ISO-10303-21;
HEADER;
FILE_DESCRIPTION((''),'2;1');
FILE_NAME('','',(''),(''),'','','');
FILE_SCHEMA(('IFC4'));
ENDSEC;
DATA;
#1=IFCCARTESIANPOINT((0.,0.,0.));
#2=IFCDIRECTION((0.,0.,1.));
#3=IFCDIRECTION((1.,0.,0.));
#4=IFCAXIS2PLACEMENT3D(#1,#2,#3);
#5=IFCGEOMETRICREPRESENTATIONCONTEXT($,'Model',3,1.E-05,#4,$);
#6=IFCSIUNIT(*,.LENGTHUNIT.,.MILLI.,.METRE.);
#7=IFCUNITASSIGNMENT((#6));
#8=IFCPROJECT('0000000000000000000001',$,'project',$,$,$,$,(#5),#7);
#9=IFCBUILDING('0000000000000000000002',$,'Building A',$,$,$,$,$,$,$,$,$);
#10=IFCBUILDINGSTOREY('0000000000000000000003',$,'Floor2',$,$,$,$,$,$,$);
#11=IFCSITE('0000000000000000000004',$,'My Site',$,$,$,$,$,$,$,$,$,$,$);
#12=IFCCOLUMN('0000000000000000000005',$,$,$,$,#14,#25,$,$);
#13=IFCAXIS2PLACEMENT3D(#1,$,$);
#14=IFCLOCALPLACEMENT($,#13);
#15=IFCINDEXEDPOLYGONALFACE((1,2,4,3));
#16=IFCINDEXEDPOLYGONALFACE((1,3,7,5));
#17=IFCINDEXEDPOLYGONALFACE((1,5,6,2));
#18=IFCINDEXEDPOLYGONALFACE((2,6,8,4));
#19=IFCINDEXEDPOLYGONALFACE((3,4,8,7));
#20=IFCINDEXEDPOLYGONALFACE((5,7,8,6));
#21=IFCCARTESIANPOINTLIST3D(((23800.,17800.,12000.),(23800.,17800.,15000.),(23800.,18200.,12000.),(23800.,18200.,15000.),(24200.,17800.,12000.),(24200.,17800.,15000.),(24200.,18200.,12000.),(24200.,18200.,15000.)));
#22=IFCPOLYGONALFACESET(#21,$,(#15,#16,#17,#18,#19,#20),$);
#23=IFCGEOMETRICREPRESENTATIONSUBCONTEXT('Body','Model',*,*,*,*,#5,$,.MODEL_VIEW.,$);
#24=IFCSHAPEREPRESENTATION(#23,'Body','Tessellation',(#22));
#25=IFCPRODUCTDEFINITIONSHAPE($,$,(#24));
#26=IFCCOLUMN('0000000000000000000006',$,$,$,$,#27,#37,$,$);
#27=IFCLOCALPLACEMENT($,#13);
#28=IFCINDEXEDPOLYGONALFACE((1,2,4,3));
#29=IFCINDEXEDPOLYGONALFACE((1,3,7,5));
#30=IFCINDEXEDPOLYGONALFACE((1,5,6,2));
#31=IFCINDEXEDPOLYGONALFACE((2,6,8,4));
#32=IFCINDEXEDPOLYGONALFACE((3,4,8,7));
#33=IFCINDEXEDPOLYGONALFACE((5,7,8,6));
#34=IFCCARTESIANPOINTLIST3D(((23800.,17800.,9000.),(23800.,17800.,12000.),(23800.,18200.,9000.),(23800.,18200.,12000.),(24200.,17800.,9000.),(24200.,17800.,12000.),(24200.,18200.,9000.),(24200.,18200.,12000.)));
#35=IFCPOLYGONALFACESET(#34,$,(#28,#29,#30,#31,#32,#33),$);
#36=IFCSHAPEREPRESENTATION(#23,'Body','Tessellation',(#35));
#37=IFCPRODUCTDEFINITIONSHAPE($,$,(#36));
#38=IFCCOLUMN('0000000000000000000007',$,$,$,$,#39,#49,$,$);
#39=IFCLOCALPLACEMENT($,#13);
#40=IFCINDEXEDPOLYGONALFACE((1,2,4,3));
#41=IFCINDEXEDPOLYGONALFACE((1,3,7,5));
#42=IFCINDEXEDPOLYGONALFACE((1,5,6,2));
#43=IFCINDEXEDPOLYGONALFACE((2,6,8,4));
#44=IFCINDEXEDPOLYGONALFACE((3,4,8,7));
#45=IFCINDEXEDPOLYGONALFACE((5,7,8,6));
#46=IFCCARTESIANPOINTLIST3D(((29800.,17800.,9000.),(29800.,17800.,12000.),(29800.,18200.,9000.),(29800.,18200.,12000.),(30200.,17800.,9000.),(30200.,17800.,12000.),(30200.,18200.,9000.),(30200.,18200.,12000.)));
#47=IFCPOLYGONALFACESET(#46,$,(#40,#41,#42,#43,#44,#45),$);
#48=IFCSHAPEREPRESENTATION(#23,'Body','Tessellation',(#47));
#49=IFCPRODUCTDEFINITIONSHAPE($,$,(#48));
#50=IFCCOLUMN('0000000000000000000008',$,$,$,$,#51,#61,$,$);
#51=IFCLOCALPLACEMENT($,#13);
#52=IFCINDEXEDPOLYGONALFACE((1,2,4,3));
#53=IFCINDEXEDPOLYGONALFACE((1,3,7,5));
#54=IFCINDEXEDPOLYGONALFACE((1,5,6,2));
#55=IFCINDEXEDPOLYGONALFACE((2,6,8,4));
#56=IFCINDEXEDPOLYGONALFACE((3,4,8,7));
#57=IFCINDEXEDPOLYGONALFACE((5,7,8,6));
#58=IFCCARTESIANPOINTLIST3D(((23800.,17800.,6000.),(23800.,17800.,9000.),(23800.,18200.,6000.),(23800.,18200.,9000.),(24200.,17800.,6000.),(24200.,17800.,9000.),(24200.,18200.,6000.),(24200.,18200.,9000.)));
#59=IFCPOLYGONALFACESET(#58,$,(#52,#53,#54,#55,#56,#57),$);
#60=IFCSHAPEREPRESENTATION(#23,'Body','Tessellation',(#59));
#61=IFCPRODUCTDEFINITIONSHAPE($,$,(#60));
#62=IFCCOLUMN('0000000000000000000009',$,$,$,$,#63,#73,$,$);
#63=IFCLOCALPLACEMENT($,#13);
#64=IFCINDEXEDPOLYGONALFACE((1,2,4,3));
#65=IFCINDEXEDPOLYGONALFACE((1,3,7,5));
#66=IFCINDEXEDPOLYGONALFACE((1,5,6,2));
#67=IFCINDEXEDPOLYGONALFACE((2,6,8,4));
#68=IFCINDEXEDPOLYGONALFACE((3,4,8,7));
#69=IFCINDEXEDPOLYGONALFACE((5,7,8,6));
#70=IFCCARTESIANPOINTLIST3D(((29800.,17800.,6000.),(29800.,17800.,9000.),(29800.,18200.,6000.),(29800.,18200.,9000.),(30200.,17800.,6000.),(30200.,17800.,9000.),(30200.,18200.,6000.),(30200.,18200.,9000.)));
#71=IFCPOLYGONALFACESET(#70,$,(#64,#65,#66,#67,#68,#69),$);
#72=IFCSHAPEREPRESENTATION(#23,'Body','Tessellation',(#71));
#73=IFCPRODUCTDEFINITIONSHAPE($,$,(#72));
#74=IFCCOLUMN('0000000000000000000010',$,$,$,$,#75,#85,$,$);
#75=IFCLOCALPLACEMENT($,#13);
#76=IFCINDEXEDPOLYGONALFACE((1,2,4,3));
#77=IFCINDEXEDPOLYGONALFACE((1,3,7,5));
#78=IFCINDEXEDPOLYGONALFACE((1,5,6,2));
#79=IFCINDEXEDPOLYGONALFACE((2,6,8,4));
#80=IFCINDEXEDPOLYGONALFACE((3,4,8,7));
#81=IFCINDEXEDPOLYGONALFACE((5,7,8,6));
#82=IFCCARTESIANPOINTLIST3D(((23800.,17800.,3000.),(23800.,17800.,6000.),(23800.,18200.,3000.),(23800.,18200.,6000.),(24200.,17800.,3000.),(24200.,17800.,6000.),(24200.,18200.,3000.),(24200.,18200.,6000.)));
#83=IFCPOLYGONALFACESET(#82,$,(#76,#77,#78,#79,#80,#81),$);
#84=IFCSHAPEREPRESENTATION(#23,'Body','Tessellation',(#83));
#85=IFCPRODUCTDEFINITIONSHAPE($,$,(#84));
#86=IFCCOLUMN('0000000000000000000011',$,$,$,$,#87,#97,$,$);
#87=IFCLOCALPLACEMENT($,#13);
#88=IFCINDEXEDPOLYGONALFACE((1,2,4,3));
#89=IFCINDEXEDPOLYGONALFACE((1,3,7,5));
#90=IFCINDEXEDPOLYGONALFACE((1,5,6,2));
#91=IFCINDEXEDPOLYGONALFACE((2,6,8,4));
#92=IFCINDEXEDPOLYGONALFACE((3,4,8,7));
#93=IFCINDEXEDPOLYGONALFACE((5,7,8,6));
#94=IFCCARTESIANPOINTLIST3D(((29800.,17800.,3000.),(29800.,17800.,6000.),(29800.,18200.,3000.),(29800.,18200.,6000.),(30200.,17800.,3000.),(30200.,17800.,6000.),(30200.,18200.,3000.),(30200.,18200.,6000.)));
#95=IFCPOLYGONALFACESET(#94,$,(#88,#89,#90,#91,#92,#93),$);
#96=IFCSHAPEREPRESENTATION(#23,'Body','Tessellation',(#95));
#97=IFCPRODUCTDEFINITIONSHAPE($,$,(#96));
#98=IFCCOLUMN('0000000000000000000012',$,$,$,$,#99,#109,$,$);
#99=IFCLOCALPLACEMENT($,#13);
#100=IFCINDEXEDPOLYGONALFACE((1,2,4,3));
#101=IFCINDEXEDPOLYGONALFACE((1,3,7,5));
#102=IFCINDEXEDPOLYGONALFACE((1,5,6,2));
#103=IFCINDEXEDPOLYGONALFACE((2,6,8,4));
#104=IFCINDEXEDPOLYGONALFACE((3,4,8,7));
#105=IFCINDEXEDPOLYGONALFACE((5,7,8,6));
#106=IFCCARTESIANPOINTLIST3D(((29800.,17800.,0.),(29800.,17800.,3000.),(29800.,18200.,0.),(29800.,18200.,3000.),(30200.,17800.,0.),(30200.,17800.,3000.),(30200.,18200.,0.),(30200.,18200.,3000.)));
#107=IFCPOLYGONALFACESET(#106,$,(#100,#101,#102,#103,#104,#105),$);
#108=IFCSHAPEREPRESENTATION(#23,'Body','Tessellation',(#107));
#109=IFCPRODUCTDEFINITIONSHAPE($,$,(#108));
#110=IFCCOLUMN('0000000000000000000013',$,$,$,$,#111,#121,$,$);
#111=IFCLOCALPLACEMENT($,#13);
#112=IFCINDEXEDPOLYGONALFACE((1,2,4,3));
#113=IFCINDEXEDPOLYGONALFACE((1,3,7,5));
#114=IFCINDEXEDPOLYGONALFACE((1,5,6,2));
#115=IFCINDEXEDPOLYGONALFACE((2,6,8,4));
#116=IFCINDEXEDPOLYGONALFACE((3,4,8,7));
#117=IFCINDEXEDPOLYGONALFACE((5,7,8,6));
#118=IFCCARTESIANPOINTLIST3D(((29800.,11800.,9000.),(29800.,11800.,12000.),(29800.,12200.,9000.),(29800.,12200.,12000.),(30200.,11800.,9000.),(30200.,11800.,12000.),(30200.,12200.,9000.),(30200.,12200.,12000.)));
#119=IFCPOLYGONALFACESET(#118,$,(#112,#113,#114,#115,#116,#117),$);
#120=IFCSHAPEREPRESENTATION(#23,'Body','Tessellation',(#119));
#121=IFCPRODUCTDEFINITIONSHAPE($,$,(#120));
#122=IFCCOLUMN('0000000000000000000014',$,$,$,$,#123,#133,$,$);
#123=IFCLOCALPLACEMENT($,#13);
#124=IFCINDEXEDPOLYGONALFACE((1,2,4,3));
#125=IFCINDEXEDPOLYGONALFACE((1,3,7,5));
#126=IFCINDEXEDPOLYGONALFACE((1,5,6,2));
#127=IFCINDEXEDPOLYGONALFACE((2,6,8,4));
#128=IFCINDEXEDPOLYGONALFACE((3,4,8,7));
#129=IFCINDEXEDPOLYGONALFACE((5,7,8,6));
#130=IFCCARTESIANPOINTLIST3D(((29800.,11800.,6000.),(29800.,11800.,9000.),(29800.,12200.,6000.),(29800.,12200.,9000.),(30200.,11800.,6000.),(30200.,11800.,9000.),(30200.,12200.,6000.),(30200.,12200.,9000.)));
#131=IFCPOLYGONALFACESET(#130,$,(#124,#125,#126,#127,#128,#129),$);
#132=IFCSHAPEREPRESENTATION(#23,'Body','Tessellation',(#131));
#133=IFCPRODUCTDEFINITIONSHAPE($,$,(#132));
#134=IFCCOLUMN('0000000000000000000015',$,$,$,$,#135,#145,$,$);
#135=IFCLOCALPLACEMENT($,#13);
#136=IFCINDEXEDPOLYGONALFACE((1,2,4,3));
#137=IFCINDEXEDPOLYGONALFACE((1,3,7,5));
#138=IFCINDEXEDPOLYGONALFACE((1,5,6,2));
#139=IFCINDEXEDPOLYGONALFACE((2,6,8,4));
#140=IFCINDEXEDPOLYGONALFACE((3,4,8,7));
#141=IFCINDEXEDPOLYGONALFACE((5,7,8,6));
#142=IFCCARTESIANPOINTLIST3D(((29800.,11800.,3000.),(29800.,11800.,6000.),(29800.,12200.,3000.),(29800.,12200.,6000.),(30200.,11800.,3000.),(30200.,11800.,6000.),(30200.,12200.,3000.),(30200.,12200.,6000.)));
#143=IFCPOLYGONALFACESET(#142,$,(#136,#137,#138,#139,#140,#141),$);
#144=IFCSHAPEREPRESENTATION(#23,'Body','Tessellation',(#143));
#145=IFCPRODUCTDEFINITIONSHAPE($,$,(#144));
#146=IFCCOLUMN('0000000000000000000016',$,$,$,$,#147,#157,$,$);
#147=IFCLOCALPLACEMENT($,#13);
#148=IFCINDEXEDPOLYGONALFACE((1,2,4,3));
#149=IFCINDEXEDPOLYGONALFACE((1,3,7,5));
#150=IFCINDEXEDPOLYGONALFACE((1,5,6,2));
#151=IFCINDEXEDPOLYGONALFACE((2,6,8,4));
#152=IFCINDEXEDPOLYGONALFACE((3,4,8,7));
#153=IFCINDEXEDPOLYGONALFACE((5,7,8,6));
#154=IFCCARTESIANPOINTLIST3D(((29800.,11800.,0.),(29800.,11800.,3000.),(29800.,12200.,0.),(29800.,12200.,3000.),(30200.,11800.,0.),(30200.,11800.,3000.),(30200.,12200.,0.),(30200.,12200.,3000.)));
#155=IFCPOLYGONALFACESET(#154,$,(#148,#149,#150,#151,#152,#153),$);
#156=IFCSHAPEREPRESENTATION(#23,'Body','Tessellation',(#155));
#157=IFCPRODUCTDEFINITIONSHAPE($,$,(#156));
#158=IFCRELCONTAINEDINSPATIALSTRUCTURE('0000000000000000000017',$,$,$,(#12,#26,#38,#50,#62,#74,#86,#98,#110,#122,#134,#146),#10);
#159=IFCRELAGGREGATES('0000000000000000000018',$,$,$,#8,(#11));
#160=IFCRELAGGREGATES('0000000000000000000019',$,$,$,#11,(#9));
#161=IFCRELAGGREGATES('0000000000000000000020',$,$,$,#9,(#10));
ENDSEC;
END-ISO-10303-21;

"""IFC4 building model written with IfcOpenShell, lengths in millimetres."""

from ifc_helpers import new_model, si_unit, frame, origin_with_axes, place, context, subcontext, project, spatial, line, indexed_curve, outline, extrude, element, save


model = new_model("IFC4")

# Units and contexts
model_context = context("Model", 3, precision=1e-05, world=origin_with_axes())
body_context = subcontext(model_context, "Body", "Model", "MODEL_VIEW")
ifc_project = project(units=[si_unit("LENGTHUNIT", "METRE", prefix="MILLI")], contexts=[model_context])

# Site, building, storey
site = spatial("IfcSite", under=ifc_project, Name="My Site")
building = spatial("IfcBuilding", under=site, Name="Building A")
storey = spatial("IfcBuildingStorey", under=building, Name="Floor2")

# Columns
for number, where, z_axis, x_axis in (
    (1, (24000.0, 18000.0, 12000.0), (0.0, 0.0, 1.0), (1.0, 0.0, 0.0)),
    (2, (24000.0, 18000.0, 9000.0), (0.0, 0.0, 1.0), (1.0, 0.0, 0.0)),
    (3, (30000.0, 18000.0, 9000.0), (0.0, 0.0, 1.0), (1.0, 0.0, 0.0)),
    (4, (24000.0, 18000.0, 6000.0), (0.0, 0.0, 1.0), (1.0, 0.0, 0.0)),
    (5, (30000.0, 18000.0, 6000.0), (0.0, 0.0, 1.0), (1.0, 0.0, 0.0)),
    (6, (24000.0, 18000.0, 3000.0), (0.0, 0.0, 1.0), (1.0, 0.0, 0.0)),
    (7, (30000.0, 18000.0, 3000.0), (0.0, 0.0, 1.0), (1.0, 0.0, 0.0)),
    (8, (30000.0, 18000.0, 0.0), (0.0, 0.0, 1.0), (1.0, 0.0, 0.0)),
    (9, (30000.0, 12000.0, 9000.0), (0.0, 0.0, 1.0), (1.0, 0.0, 0.0)),
    (10, (30000.0, 12000.0, 6000.0), (0.0, 0.0, 1.0), (1.0, 0.0, 0.0)),
    (11, (30000.0, 12000.0, 3000.0), (0.0, 0.0, 1.0), (1.0, 0.0, 0.0)),
    (12, (30000.0, 12000.0, 0.0), (0.0, 0.0, 1.0), (1.0, 0.0, 0.0)),
):
    element("IfcColumn", number, at=place(None, frame(where, z_axis=z_axis, x_axis=x_axis)), inside=storey, context=body_context, shape_type="SweptSolid", body=[
        extrude(outline(indexed_curve([(-200.0, -200.0), (200.0, -200.0), (200.0, 200.0), (-200.0, 200.0)], segments=[line(1, 2, 3, 4, 1)])), origin_with_axes(), (0.0, 0.0, 1.0), 3000.0),
    ])

save(model, "model.ifc")
